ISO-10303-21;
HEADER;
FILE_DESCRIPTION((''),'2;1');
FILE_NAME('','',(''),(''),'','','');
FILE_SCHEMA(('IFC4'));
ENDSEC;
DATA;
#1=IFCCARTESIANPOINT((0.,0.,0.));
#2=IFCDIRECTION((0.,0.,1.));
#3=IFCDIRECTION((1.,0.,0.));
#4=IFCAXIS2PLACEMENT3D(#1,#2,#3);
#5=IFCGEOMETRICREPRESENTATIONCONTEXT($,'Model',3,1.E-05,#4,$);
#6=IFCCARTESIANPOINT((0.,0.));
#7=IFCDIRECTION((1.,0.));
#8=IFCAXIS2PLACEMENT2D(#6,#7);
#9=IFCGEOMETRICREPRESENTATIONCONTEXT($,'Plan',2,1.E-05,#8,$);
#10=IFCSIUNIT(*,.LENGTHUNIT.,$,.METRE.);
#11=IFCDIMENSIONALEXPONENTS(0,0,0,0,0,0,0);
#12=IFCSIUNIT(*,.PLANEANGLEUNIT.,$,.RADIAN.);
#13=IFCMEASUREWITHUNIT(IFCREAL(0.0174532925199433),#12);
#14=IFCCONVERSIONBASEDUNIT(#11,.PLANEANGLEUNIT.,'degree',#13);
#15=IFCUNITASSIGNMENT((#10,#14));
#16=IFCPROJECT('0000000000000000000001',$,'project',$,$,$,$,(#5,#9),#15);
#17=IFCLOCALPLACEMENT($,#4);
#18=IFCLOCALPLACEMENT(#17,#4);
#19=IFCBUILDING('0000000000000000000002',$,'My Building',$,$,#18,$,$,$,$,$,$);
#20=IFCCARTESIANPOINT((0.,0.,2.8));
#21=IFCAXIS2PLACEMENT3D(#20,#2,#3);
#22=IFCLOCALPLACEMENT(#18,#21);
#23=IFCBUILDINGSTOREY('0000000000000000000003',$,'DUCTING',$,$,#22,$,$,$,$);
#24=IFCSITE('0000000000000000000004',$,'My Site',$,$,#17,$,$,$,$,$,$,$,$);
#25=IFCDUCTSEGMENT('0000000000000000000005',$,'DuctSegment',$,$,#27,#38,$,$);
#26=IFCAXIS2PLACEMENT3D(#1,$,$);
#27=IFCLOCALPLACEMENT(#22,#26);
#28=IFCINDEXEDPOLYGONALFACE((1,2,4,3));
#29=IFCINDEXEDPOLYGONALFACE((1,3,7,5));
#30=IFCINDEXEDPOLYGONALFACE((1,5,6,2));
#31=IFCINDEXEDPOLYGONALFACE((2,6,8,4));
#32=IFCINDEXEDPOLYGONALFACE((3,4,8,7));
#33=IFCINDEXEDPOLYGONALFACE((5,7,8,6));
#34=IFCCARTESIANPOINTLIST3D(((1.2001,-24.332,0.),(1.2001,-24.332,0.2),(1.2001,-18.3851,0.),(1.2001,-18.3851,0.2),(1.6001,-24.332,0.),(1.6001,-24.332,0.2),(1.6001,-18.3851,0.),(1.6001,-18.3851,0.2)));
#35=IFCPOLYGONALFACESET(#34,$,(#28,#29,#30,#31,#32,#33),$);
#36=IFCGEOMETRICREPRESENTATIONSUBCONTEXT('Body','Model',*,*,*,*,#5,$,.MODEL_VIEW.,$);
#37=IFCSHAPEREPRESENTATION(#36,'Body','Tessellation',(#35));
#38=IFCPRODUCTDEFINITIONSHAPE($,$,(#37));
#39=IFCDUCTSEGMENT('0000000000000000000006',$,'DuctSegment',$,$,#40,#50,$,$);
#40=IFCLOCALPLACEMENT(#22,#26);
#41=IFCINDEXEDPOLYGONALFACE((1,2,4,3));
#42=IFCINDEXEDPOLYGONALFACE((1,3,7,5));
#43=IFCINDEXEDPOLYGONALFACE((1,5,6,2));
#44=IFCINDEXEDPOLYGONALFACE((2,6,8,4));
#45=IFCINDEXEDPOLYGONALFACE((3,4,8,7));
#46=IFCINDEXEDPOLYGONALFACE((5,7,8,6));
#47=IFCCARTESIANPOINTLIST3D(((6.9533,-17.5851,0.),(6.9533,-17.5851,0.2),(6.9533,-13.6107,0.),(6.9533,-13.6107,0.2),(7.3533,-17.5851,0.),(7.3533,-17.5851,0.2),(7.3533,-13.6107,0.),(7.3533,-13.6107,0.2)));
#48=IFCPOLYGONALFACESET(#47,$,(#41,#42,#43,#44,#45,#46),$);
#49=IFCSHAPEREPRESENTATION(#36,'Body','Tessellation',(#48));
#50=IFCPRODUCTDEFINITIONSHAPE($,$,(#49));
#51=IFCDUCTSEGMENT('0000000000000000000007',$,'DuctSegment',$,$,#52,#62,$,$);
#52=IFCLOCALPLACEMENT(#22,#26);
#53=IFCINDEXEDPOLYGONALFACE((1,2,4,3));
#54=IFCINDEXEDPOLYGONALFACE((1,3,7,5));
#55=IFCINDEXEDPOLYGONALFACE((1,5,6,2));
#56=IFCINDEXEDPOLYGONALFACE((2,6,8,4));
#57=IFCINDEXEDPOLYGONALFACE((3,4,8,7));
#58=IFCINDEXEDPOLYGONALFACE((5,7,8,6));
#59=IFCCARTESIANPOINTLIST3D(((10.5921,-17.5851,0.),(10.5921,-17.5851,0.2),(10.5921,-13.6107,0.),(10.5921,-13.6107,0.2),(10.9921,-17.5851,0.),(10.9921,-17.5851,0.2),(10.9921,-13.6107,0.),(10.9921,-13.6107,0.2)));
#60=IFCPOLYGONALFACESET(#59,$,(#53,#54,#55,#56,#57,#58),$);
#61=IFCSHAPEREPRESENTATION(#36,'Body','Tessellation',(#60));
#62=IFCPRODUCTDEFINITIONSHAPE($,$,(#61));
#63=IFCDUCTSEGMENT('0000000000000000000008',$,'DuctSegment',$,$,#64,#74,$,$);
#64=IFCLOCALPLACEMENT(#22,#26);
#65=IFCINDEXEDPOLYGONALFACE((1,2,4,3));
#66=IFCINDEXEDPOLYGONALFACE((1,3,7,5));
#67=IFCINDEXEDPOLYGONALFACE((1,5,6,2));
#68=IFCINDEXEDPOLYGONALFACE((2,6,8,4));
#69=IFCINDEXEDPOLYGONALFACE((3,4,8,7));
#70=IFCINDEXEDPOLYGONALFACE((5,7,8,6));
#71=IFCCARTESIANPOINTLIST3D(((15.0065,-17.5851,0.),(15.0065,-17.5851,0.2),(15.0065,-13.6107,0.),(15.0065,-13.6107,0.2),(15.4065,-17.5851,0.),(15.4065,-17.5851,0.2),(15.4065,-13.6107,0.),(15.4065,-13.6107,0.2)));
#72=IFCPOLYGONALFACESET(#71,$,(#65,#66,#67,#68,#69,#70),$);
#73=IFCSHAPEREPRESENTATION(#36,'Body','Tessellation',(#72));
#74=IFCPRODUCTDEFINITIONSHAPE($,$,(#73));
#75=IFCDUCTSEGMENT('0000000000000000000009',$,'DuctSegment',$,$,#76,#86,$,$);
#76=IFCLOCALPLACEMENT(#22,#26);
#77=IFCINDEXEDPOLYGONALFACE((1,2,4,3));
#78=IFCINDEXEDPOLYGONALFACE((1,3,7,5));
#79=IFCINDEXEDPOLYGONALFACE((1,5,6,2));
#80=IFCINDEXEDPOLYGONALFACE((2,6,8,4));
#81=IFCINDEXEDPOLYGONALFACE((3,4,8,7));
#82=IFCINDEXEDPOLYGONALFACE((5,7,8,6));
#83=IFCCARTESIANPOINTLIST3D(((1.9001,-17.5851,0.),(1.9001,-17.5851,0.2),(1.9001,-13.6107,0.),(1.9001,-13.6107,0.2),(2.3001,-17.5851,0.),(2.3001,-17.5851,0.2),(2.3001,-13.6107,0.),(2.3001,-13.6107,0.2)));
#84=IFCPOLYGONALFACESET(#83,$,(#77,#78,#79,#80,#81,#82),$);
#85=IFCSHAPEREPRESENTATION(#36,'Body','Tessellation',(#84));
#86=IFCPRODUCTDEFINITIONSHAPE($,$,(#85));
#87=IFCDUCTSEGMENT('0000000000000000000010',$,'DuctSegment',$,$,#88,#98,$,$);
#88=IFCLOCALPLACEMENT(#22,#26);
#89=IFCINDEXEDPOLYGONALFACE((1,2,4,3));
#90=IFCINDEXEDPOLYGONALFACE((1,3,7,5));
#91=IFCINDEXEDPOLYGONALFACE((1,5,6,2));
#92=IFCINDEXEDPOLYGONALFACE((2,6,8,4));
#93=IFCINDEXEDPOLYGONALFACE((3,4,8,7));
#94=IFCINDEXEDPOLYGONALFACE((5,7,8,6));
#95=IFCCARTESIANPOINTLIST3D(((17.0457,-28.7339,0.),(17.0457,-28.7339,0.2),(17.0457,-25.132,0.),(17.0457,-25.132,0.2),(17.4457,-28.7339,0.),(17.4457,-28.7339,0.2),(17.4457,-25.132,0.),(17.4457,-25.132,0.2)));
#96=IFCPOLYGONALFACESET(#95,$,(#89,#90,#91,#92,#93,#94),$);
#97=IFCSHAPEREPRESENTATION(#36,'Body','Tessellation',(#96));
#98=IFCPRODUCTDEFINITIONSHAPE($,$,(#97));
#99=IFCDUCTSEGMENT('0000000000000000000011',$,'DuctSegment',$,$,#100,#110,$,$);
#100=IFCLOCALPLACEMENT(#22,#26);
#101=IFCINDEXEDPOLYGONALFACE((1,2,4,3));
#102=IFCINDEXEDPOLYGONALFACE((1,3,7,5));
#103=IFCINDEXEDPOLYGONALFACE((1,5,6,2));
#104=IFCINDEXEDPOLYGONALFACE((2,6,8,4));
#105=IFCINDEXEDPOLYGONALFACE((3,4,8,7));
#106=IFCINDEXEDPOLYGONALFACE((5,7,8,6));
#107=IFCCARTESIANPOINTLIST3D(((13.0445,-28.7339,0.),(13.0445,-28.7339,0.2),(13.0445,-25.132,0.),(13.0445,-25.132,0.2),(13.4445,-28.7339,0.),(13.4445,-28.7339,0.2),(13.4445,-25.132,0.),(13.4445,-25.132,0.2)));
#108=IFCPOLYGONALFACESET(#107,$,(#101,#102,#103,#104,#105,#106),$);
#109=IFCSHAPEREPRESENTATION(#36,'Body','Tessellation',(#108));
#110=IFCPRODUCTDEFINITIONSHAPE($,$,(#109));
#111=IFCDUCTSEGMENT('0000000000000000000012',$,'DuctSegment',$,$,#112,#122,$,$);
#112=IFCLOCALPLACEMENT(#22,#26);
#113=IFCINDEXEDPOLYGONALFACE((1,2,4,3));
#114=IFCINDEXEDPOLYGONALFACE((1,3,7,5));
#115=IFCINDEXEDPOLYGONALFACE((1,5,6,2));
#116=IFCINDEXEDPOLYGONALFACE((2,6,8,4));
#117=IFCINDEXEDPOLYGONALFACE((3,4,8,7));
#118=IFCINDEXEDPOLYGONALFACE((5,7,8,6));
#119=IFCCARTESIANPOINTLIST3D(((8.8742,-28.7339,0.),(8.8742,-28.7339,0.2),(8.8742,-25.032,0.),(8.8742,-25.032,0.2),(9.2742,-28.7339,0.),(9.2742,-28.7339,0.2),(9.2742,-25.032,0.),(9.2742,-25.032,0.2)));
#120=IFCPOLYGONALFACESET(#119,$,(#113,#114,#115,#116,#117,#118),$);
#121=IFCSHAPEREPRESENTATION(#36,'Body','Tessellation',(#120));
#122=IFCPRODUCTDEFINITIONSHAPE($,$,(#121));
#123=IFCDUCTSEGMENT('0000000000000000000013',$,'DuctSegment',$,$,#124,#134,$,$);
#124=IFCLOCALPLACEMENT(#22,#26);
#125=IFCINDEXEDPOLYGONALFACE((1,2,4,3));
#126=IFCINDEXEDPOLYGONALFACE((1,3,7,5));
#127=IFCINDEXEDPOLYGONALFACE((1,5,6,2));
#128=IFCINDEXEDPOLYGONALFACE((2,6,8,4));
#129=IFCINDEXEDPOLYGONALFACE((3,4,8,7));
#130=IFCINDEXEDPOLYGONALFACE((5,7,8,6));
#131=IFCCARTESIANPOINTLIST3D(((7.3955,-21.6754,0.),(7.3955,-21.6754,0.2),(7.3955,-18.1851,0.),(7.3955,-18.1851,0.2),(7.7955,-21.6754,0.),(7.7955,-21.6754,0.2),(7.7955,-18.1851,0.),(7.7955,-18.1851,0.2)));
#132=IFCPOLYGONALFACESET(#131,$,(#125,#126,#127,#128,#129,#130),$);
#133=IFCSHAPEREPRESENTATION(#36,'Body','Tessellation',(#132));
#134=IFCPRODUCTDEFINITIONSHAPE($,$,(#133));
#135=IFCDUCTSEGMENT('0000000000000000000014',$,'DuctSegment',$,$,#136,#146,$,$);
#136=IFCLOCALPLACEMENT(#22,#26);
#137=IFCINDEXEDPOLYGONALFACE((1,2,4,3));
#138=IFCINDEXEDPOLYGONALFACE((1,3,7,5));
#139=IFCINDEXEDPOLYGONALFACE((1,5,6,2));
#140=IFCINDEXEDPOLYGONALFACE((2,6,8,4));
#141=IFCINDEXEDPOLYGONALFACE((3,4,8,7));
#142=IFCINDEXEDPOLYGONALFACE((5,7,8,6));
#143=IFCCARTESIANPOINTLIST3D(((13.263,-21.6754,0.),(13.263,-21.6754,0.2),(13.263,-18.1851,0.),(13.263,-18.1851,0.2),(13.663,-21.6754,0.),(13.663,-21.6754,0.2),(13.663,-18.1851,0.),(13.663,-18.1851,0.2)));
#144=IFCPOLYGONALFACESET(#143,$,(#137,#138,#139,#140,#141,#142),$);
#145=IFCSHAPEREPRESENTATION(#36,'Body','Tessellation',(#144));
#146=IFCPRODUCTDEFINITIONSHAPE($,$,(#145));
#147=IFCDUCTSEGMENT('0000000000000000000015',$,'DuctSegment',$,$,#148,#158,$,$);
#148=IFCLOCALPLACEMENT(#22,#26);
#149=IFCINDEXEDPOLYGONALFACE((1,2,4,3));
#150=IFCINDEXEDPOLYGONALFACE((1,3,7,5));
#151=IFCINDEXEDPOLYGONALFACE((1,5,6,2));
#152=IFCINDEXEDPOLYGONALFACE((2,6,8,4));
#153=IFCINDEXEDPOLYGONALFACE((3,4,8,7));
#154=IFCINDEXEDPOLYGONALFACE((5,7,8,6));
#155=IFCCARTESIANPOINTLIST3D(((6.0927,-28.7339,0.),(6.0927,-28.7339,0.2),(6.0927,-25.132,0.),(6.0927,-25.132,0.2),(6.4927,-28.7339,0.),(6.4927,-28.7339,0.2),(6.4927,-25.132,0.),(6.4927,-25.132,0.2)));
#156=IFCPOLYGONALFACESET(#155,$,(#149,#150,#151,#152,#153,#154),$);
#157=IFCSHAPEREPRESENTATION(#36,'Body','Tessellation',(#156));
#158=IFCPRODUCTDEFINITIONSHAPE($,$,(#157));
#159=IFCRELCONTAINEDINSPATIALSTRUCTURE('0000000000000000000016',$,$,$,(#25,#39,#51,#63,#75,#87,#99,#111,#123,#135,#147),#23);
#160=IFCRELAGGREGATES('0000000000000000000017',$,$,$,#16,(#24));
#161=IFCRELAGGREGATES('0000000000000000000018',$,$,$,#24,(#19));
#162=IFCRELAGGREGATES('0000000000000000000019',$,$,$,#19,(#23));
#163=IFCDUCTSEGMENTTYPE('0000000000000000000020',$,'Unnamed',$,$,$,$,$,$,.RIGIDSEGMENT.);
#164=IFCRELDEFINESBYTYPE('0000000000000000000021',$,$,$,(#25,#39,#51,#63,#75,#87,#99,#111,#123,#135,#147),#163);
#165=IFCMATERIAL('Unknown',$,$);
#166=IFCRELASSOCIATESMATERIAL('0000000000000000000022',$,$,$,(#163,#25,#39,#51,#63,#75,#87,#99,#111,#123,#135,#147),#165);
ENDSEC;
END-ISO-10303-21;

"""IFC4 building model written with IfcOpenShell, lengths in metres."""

from ifc_helpers import new_model, entity, si_unit, converted_unit, frame, origin_with_axes, origin_2d_with_axis, place, context, subcontext, project, spatial, rectangle, extrude, material, material_profile, profile_set, profile_usage, type_object, element, save


model = new_model("IFC4")

# Units and contexts
model_context = context("Model", 3, precision=1e-05, world=origin_with_axes())
plan_context = context("Plan", 2, precision=1e-05, world=origin_2d_with_axis())
body_context = subcontext(model_context, "Body", "Model", "MODEL_VIEW")
ifc_project = project(units=[si_unit("LENGTHUNIT", "METRE"), converted_unit("PLANEANGLEUNIT", "degree", entity("IfcReal", 0.0174532925199433), si_unit("PLANEANGLEUNIT", "RADIAN"), dimensions=[0, 0, 0, 0, 0, 0, 0])], contexts=[model_context, plan_context])

# Site, building, storey
site_placement = place(None, origin_with_axes())
site = spatial("IfcSite", under=ifc_project, at=site_placement, Name="My Site")
building_placement = place(site_placement, origin_with_axes())
building = spatial("IfcBuilding", under=site, at=building_placement, Name="My Building")
storey_placement = place(building_placement, frame((0.0, 0.0, 2.8), z_axis=(0.0, 0.0, 1.0), x_axis=(1.0, 0.0, 0.0)))
storey = spatial("IfcBuildingStorey", under=building, at=storey_placement, Name="DUCTING")

# Duct segments
ifc_material = material(Name="Unknown")
ifc_material_profile_1 = material_profile(ifc_material, rectangle(XDim=0.4, YDim=0.2))
ifc_profile_set_1 = profile_set([ifc_material_profile_1])
ifc_profile_usage_1 = profile_usage(ifc_profile_set_1, cardinal=5)
duct_segment_type = type_object("IfcDuctSegmentType", Name="Unnamed", PredefinedType="RIGIDSEGMENT", material=ifc_profile_set_1)
duct_segment_1_placement = place(storey_placement, frame((1.4001, -24.332, 0.1), z_axis=(0.0, 1.0, 0.0), x_axis=(-1.0, 0.0, 0.0)))
element("IfcDuctSegment", 1, at=duct_segment_1_placement, inside=storey, type_object=duct_segment_type, material=ifc_profile_usage_1, Name="DuctSegment", context=body_context, shape_type="SweptSolid", body=[
    extrude(rectangle(XDim=0.4, YDim=0.2), origin_with_axes(), (0.0, 0.0, 1.0), 5.9469),
])
ifc_profile_usage_2 = profile_usage(ifc_profile_set_1, cardinal=5)
duct_segment_2_placement = place(storey_placement, frame((7.1533, -17.5851, 0.1), z_axis=(0.0, 1.0, 0.0), x_axis=(-1.0, 0.0, 0.0)))
element("IfcDuctSegment", 2, at=duct_segment_2_placement, inside=storey, type_object=duct_segment_type, material=ifc_profile_usage_2, Name="DuctSegment", context=body_context, shape_type="SweptSolid", body=[
    extrude(rectangle(XDim=0.4, YDim=0.2), origin_with_axes(), (0.0, 0.0, 1.0), 3.9744),
])
ifc_profile_usage_3 = profile_usage(ifc_profile_set_1, cardinal=5)
duct_segment_3_placement = place(storey_placement, frame((10.7921, -17.5851, 0.1), z_axis=(0.0, 1.0, 0.0), x_axis=(-1.0, 0.0, 0.0)))
element("IfcDuctSegment", 3, at=duct_segment_3_placement, inside=storey, type_object=duct_segment_type, material=ifc_profile_usage_3, Name="DuctSegment", context=body_context, shape_type="SweptSolid", body=[
    extrude(rectangle(XDim=0.4, YDim=0.2), origin_with_axes(), (0.0, 0.0, 1.0), 3.9744),
])
ifc_profile_usage_4 = profile_usage(ifc_profile_set_1, cardinal=5)
duct_segment_4_placement = place(storey_placement, frame((15.2065, -17.5851, 0.1), z_axis=(0.0, 1.0, 0.0), x_axis=(-1.0, 0.0, 0.0)))
element("IfcDuctSegment", 4, at=duct_segment_4_placement, inside=storey, type_object=duct_segment_type, material=ifc_profile_usage_4, Name="DuctSegment", context=body_context, shape_type="SweptSolid", body=[
    extrude(rectangle(XDim=0.4, YDim=0.2), origin_with_axes(), (0.0, 0.0, 1.0), 3.9744),
])
ifc_profile_usage_5 = profile_usage(ifc_profile_set_1, cardinal=5)
duct_segment_5_placement = place(storey_placement, frame((2.1001, -17.5851, 0.1), z_axis=(0.0, 1.0, 0.0), x_axis=(-1.0, 0.0, 0.0)))
element("IfcDuctSegment", 5, at=duct_segment_5_placement, inside=storey, type_object=duct_segment_type, material=ifc_profile_usage_5, Name="DuctSegment", context=body_context, shape_type="SweptSolid", body=[
    extrude(rectangle(XDim=0.4, YDim=0.2), origin_with_axes(), (0.0, 0.0, 1.0), 3.9744),
])
ifc_profile_usage_6 = profile_usage(ifc_profile_set_1, cardinal=5)
duct_segment_6_placement = place(storey_placement, frame((17.2457, -25.132, 0.1), z_axis=(0.0, -1.0, 0.0), x_axis=(1.0, 0.0, 0.0)))
element("IfcDuctSegment", 6, at=duct_segment_6_placement, inside=storey, type_object=duct_segment_type, material=ifc_profile_usage_6, Name="DuctSegment", context=body_context, shape_type="SweptSolid", body=[
    extrude(rectangle(XDim=0.4, YDim=0.2), origin_with_axes(), (0.0, 0.0, 1.0), 3.6018),
])
ifc_profile_usage_7 = profile_usage(ifc_profile_set_1, cardinal=5)
duct_segment_7_placement = place(storey_placement, frame((13.2445, -25.132, 0.1), z_axis=(0.0, -1.0, 0.0), x_axis=(1.0, 0.0, 0.0)))
element("IfcDuctSegment", 7, at=duct_segment_7_placement, inside=storey, type_object=duct_segment_type, material=ifc_profile_usage_7, Name="DuctSegment", context=body_context, shape_type="SweptSolid", body=[
    extrude(rectangle(XDim=0.4, YDim=0.2), origin_with_axes(), (0.0, 0.0, 1.0), 3.6018),
])
ifc_profile_usage_8 = profile_usage(ifc_profile_set_1, cardinal=5)
duct_segment_8_placement = place(storey_placement, frame((9.0742, -25.032, 0.1), z_axis=(0.0, -1.0, 0.0), x_axis=(1.0, 0.0, 0.0)))
element("IfcDuctSegment", 8, at=duct_segment_8_placement, inside=storey, type_object=duct_segment_type, material=ifc_profile_usage_8, Name="DuctSegment", context=body_context, shape_type="SweptSolid", body=[
    extrude(rectangle(XDim=0.4, YDim=0.2), origin_with_axes(), (0.0, 0.0, 1.0), 3.7018),
])
ifc_profile_usage_9 = profile_usage(ifc_profile_set_1, cardinal=5)
duct_segment_9_placement = place(storey_placement, frame((7.5955, -18.1851, 0.1), z_axis=(0.0, -1.0, 0.0), x_axis=(1.0, 0.0, 0.0)))
element("IfcDuctSegment", 9, at=duct_segment_9_placement, inside=storey, type_object=duct_segment_type, material=ifc_profile_usage_9, Name="DuctSegment", context=body_context, shape_type="SweptSolid", body=[
    extrude(rectangle(XDim=0.4, YDim=0.2), origin_with_axes(), (0.0, 0.0, 1.0), 3.4903),
])
ifc_profile_usage_10 = profile_usage(ifc_profile_set_1, cardinal=5)
duct_segment_10_placement = place(storey_placement, frame((13.463, -18.1851, 0.1), z_axis=(0.0, -1.0, 0.0), x_axis=(1.0, 0.0, 0.0)))
element("IfcDuctSegment", 10, at=duct_segment_10_placement, inside=storey, type_object=duct_segment_type, material=ifc_profile_usage_10, Name="DuctSegment", context=body_context, shape_type="SweptSolid", body=[
    extrude(rectangle(XDim=0.4, YDim=0.2), origin_with_axes(), (0.0, 0.0, 1.0), 3.4903),
])
ifc_profile_usage_11 = profile_usage(ifc_profile_set_1, cardinal=5)
duct_segment_11_placement = place(storey_placement, frame((6.2927, -25.132, 0.1), z_axis=(0.0, -1.0, 0.0), x_axis=(1.0, 0.0, 0.0)))
element("IfcDuctSegment", 11, at=duct_segment_11_placement, inside=storey, type_object=duct_segment_type, material=ifc_profile_usage_11, Name="DuctSegment", context=body_context, shape_type="SweptSolid", body=[
    extrude(rectangle(XDim=0.4, YDim=0.2), origin_with_axes(), (0.0, 0.0, 1.0), 3.6018),
])

save(model, "model.ifc")
